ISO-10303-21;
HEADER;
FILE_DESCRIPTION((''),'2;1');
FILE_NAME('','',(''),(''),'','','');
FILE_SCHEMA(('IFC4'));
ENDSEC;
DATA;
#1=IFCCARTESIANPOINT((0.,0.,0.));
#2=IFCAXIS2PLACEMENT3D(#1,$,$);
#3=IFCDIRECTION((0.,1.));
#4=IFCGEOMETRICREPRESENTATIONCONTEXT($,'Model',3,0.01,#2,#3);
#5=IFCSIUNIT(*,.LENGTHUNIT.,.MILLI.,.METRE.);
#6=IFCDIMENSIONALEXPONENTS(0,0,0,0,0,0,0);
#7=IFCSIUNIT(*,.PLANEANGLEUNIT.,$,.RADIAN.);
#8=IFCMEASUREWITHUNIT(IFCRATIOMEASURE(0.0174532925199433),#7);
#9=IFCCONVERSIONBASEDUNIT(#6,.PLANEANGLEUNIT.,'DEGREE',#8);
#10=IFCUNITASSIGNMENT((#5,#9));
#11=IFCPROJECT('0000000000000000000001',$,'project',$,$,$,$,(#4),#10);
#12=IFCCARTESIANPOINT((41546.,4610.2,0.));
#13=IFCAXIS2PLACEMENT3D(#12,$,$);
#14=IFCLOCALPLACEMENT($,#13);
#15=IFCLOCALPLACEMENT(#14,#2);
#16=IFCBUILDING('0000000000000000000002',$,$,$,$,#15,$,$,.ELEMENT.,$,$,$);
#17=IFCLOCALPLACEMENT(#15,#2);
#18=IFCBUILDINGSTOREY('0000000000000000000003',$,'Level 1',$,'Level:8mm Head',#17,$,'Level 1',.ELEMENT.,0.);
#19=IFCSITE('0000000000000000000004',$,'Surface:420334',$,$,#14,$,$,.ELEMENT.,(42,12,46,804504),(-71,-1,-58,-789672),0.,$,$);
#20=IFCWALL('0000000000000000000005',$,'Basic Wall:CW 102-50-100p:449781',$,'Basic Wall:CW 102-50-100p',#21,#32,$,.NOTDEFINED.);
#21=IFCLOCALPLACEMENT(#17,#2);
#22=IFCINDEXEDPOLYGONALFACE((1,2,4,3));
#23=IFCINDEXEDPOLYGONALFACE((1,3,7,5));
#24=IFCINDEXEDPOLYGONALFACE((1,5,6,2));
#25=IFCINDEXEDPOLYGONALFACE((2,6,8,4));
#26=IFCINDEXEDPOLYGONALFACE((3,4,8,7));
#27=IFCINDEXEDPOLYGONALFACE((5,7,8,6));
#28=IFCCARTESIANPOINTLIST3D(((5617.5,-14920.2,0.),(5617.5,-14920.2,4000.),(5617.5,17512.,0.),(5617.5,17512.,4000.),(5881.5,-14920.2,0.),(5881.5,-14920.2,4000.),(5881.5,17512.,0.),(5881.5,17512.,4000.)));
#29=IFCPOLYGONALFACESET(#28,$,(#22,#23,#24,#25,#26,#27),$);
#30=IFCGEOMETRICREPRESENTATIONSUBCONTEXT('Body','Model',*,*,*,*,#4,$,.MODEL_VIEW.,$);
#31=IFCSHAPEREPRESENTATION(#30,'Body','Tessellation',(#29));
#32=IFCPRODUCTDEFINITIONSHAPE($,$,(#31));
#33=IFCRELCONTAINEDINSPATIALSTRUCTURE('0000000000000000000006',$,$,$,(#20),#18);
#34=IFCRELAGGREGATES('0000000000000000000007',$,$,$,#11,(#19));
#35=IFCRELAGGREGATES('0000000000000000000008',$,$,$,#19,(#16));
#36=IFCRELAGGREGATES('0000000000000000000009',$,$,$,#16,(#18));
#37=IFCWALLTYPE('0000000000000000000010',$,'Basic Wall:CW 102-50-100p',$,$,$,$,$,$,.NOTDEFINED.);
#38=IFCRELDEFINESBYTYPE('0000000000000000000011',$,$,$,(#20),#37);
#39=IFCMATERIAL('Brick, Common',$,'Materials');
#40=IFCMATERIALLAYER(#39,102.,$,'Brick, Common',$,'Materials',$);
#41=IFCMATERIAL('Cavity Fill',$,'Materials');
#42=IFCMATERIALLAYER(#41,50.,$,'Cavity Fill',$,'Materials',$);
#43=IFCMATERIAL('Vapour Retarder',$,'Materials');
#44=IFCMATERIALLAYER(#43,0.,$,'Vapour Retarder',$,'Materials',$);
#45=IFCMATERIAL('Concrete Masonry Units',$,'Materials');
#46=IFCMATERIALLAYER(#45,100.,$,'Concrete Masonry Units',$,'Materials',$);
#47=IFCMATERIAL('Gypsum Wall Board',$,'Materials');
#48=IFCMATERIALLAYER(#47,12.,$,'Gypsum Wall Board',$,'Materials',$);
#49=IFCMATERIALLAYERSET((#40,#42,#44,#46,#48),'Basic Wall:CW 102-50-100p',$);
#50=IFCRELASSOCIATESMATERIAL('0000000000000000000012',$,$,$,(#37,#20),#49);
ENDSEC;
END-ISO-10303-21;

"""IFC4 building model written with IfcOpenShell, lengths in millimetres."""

from ifc_helpers import new_model, entity, si_unit, converted_unit, direction, frame, frame_2d, origin, place, context, subcontext, project, spatial, rectangle, extrude, material, layer, layer_set, layer_usage, type_object, element, save


model = new_model("IFC4")

# Units and contexts
model_context = context("Model", 3, precision=0.01, world=origin(), true_north=direction((0.0, 1.0)))
body_context = subcontext(model_context, "Body", "Model", "MODEL_VIEW")
ifc_project = project(units=[si_unit("LENGTHUNIT", "METRE", prefix="MILLI"), converted_unit("PLANEANGLEUNIT", "DEGREE", entity("IfcRatioMeasure", 0.0174532925199433), si_unit("PLANEANGLEUNIT", "RADIAN"), dimensions=[0, 0, 0, 0, 0, 0, 0])], contexts=[model_context])

# Site, building, storey
site_placement = place(None, frame((41546.0, 4610.2, 0.0)))
site = spatial("IfcSite", under=ifc_project, at=site_placement, Name="Surface:420334", CompositionType="ELEMENT", RefLatitude=(42, 12, 46, 804504), RefLongitude=(-71, -1, -58, -789672), RefElevation=0.0)
building_placement = place(site_placement, origin())
building = spatial("IfcBuilding", under=site, at=building_placement, CompositionType="ELEMENT")
storey_placement = place(building_placement, origin())
storey = spatial("IfcBuildingStorey", under=building, at=storey_placement, Name="Level 1", ObjectType="Level:8mm Head", LongName="Level 1", CompositionType="ELEMENT", Elevation=0.0)

# Wall
ifc_material_1 = material(Name="Brick, Common", Category="Materials")
ifc_layer_1 = layer(ifc_material_1, 102.0, Name="Brick, Common", Category="Materials")
ifc_material_2 = material(Name="Cavity Fill", Category="Materials")
ifc_layer_2 = layer(ifc_material_2, 50.0, Name="Cavity Fill", Category="Materials")
ifc_material_3 = material(Name="Vapour Retarder", Category="Materials")
ifc_layer_3 = layer(ifc_material_3, 0.0, Name="Vapour Retarder", Category="Materials")
ifc_material_4 = material(Name="Concrete Masonry Units", Category="Materials")
ifc_layer_4 = layer(ifc_material_4, 100.0, Name="Concrete Masonry Units", Category="Materials")
ifc_material_5 = material(Name="Gypsum Wall Board", Category="Materials")
ifc_layer_5 = layer(ifc_material_5, 12.0, Name="Gypsum Wall Board", Category="Materials")
ifc_layer_set_1 = layer_set([ifc_layer_1, ifc_layer_2, ifc_layer_3, ifc_layer_4, ifc_layer_5], Name="Basic Wall:CW 102-50-100p")
ifc_layer_usage_1 = layer_usage(ifc_layer_set_1, "AXIS2", "POSITIVE", -132.0)
wall_type = type_object("IfcWallType", Name="Basic Wall:CW 102-50-100p", PredefinedType="NOTDEFINED", material=ifc_layer_set_1)
wall_placement = place(storey_placement, frame((5749.5, 17512.0, 0.0), z_axis=(0.0, 0.0, 1.0), x_axis=(0.0, -1.0, 0.0)))
element("IfcWall", 1, at=wall_placement, inside=storey, type_object=wall_type, material=ifc_layer_usage_1, Name="Basic Wall:CW 102-50-100p:449781", ObjectType="Basic Wall:CW 102-50-100p", PredefinedType="NOTDEFINED", context=body_context, shape_type="SweptSolid", body=[
    extrude(rectangle(XDim=32432.2, YDim=264.0, at=frame_2d((16216.1, 0.0), x_axis=(-1.0, 0.0))), origin(), (0.0, 0.0, 1.0), 4000.0),
])

save(model, "model.ifc")
